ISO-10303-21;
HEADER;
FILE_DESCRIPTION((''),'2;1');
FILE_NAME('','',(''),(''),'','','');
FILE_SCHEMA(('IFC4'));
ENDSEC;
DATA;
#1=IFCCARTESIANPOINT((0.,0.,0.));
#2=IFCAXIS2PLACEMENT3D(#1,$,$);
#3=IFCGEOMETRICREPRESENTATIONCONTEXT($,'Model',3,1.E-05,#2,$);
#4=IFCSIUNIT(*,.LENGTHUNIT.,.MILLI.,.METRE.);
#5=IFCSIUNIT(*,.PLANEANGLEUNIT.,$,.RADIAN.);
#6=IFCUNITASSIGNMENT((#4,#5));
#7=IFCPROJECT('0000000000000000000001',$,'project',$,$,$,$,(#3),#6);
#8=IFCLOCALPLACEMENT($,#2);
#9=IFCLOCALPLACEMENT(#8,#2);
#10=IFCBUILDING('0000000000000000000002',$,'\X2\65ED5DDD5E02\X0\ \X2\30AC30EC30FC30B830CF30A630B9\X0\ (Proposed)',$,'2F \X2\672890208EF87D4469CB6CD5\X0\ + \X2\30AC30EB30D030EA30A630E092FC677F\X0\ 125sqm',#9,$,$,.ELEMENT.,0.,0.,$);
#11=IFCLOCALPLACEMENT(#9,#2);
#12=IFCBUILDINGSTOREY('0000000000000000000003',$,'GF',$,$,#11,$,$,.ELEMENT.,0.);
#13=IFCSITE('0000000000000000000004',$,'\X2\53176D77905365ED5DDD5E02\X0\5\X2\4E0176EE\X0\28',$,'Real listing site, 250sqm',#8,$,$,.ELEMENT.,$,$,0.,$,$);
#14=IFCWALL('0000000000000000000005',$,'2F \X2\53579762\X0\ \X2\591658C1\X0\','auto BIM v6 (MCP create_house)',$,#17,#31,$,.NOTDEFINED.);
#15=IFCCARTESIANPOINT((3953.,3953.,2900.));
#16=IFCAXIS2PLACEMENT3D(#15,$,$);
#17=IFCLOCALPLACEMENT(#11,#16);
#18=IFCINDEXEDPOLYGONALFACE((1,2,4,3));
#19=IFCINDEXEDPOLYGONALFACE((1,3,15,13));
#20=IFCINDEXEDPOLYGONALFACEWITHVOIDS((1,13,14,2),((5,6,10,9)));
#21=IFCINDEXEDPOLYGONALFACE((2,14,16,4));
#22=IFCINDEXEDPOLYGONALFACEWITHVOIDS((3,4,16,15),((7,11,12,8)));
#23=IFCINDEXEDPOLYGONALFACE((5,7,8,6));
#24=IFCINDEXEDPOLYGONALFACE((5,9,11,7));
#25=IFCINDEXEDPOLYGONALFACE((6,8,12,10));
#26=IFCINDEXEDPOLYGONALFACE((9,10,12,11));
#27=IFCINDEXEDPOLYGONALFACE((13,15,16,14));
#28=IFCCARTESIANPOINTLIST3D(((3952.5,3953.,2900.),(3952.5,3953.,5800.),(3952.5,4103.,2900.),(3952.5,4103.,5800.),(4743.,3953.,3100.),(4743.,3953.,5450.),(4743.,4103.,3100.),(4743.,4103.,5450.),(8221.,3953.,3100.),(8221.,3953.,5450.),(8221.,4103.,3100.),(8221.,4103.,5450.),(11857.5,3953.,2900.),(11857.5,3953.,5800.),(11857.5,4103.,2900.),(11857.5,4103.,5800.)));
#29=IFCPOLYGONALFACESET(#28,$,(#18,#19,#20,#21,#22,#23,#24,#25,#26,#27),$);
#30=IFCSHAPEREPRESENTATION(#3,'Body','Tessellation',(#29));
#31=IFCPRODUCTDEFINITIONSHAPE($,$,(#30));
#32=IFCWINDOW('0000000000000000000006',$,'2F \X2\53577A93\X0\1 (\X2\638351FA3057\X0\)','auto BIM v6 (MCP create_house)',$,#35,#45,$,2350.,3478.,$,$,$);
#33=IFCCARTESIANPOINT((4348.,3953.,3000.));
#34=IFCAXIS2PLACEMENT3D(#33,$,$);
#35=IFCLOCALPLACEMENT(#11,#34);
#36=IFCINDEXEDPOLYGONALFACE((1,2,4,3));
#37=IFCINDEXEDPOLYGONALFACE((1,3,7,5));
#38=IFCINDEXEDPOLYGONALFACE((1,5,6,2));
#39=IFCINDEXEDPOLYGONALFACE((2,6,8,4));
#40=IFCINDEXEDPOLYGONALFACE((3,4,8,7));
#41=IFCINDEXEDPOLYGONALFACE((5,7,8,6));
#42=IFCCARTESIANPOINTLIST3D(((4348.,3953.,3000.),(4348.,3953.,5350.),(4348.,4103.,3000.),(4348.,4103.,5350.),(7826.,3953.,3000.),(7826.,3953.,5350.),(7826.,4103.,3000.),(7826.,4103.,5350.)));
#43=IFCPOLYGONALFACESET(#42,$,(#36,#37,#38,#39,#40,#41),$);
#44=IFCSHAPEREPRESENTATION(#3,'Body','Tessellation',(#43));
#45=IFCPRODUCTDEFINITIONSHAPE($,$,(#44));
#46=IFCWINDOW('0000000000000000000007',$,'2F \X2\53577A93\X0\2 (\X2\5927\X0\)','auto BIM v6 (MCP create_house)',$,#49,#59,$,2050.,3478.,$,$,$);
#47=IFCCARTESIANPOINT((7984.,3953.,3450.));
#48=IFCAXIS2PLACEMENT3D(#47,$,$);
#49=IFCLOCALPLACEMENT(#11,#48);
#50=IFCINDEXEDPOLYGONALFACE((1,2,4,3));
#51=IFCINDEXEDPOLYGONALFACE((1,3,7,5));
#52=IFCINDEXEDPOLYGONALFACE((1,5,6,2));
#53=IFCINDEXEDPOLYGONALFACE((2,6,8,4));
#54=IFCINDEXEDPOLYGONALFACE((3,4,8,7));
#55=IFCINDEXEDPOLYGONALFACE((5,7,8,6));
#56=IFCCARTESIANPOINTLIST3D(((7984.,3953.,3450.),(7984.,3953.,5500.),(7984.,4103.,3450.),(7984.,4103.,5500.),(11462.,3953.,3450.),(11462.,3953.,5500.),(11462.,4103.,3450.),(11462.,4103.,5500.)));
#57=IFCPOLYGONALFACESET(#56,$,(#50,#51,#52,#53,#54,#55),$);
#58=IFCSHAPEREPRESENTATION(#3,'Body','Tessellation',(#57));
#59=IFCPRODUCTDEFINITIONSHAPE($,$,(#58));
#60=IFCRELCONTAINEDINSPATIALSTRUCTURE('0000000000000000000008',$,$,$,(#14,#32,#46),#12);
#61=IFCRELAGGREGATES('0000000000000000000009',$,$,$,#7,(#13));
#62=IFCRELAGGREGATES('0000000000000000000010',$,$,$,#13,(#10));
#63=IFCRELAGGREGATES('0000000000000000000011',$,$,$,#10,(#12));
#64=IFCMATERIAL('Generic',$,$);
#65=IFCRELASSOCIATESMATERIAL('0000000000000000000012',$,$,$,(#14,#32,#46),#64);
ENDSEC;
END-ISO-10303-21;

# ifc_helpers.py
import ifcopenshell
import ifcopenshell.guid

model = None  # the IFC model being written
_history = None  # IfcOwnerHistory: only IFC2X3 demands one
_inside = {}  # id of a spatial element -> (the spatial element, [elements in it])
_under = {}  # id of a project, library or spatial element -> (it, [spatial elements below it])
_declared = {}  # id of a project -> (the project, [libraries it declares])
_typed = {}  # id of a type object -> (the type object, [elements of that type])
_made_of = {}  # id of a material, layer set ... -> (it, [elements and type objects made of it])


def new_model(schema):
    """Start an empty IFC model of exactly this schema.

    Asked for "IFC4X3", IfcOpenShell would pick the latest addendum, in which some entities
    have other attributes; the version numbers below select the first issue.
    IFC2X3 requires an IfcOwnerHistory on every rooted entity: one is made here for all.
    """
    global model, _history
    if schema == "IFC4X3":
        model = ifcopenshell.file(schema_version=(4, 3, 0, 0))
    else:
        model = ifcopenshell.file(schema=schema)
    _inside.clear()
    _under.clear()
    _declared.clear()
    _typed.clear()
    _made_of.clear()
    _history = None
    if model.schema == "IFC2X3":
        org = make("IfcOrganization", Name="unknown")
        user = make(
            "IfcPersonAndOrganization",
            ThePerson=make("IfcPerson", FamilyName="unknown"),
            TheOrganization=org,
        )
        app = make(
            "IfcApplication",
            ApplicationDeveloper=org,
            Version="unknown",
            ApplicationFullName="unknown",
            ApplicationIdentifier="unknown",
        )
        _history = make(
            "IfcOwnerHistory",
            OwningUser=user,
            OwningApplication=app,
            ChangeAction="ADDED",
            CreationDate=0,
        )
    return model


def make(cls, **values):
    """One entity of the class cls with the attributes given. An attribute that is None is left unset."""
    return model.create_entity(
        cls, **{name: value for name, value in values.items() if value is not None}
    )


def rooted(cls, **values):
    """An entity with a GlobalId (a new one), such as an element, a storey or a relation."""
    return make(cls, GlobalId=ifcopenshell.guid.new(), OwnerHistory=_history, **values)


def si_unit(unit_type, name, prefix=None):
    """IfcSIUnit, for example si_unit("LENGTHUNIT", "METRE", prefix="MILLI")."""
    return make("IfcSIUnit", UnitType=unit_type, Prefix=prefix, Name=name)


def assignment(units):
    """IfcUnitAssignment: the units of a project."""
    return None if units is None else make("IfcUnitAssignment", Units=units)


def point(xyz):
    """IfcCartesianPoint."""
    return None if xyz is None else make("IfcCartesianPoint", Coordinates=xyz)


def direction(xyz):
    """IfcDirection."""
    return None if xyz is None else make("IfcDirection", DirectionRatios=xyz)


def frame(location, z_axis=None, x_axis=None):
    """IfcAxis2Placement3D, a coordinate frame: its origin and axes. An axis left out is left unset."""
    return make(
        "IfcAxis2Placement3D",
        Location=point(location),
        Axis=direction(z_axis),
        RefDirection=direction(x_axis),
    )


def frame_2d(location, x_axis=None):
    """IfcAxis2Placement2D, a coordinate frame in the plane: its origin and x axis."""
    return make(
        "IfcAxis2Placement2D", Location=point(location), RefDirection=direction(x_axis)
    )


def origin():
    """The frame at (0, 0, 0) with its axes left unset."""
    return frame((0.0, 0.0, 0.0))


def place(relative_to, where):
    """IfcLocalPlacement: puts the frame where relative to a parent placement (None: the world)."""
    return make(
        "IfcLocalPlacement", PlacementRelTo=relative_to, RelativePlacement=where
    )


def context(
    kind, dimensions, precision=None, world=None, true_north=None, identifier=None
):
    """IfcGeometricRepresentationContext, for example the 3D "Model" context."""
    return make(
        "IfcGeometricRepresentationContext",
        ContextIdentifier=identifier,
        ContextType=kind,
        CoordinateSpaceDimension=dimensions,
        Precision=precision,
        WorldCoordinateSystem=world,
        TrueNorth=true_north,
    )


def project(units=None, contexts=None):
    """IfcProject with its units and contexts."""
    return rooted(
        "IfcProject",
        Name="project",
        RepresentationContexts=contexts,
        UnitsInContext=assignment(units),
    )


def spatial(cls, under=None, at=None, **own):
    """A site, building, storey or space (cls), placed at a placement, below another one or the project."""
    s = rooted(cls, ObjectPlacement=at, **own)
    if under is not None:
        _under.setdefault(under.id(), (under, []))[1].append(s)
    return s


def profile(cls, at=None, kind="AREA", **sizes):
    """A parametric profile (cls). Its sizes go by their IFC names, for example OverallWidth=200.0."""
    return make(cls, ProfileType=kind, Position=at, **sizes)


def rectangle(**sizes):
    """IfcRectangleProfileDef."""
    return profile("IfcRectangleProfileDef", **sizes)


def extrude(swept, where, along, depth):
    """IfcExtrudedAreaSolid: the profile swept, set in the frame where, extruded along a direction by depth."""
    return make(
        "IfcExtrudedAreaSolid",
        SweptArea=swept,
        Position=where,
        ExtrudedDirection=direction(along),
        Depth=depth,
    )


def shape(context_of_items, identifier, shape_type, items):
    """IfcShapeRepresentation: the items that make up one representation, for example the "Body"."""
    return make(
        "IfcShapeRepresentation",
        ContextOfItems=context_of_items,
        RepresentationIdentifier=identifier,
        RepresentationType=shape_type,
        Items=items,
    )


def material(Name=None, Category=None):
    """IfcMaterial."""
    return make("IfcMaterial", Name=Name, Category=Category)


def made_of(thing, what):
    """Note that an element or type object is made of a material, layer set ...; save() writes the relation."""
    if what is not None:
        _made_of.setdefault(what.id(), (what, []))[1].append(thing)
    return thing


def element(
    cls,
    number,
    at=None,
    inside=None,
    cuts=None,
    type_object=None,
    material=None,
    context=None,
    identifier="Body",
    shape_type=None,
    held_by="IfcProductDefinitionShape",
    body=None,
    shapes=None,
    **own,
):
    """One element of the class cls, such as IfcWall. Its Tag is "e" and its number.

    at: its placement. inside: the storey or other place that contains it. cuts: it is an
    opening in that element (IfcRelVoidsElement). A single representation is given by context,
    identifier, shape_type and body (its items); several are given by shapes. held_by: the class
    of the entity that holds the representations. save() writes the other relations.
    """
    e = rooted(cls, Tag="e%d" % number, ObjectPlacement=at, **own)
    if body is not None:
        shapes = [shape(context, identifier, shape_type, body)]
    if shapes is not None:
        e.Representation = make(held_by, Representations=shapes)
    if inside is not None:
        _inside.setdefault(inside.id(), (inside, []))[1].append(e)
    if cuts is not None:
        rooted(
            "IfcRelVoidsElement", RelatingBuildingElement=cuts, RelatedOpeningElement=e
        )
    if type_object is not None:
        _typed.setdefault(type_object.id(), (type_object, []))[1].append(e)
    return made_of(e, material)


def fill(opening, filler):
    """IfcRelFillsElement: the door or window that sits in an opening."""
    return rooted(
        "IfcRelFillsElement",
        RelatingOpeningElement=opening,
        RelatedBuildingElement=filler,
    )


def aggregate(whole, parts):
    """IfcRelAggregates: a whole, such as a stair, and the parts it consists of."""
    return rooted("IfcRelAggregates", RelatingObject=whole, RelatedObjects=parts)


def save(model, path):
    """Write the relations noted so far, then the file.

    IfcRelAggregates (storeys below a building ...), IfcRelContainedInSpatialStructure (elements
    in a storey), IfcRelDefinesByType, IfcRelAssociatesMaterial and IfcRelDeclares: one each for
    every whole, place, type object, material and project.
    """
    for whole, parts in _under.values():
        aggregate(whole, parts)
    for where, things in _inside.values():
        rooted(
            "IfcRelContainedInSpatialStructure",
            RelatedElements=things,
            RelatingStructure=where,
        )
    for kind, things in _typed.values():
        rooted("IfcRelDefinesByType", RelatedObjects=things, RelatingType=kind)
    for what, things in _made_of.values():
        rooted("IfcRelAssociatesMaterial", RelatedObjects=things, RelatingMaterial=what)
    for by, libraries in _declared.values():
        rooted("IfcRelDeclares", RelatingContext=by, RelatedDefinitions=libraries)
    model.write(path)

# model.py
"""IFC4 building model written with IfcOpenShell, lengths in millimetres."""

from ifc_helpers import new_model, si_unit, frame, frame_2d, origin, place, context, project, spatial, rectangle, extrude, material, element, fill, save


model = new_model("IFC4")

# Units and contexts
model_context = context("Model", 3, precision=1e-05, world=origin())
ifc_project = project(units=[si_unit("LENGTHUNIT", "METRE", prefix="MILLI"), si_unit("PLANEANGLEUNIT", "RADIAN")], contexts=[model_context])

# Site, building, storey
site_placement = place(None, origin())
site = spatial("IfcSite", under=ifc_project, at=site_placement, Name="北海道旭川市5丁目28", ObjectType="Real listing site, 250sqm", CompositionType="ELEMENT", RefElevation=0.0)
building_placement = place(site_placement, origin())
building = spatial("IfcBuilding", under=site, at=building_placement, Name="旭川市 ガレージハウス (Proposed)", ObjectType="2F 木造軸組構法 + ガルバリウム鋼板 125sqm", CompositionType="ELEMENT", ElevationOfRefHeight=0.0, ElevationOfTerrain=0.0)
storey_placement = place(building_placement, origin())
storey = spatial("IfcBuildingStorey", under=building, at=storey_placement, Name="GF", CompositionType="ELEMENT", Elevation=0.0)

# Shared definitions
ifc_material = material(Name="Generic")

# Wall, openings, windows
wall_1_placement = place(storey_placement, frame((3953.0, 3953.0, 2900.0)))
wall_1 = element("IfcWall", 1, at=wall_1_placement, inside=storey, material=ifc_material, Name="2F 南面 外壁", Description="auto BIM v6 (MCP create_house)", PredefinedType="NOTDEFINED", context=model_context, shape_type="SweptSolid", body=[
    extrude(rectangle(XDim=7905.0, YDim=150.0, at=frame_2d((3952.0, 75.0))), frame((3953.0, 3953.0, 2900.0)), (0.0, 0.0, 1.0), 2900.0),
])
opening_1_placement = place(storey_placement, frame((4348.0, 3953.0, 3000.0)))
opening_1 = element("IfcOpeningElement", 2, at=opening_1_placement, cuts=wall_1, PredefinedType="NOTDEFINED", context=model_context, shape_type="SweptSolid", body=[
    extrude(rectangle(XDim=3478.0, YDim=150.0, at=frame_2d((1739.0, 75.0))), frame((4348.0, 3953.0, 3000.0)), (0.0, 0.0, 1.0), 2350.0),
])
opening_2_placement = place(storey_placement, frame((7984.0, 3953.0, 3450.0)))
opening_2 = element("IfcOpeningElement", 3, at=opening_2_placement, cuts=wall_1, PredefinedType="NOTDEFINED", context=model_context, shape_type="SweptSolid", body=[
    extrude(rectangle(XDim=3478.0, YDim=150.0, at=frame_2d((1739.0, 75.0))), frame((7984.0, 3953.0, 3450.0)), (0.0, 0.0, 1.0), 2050.0),
])
window_1_placement = place(storey_placement, frame((4348.0, 3953.0, 3000.0)))
window_1 = element("IfcWindow", 4, at=window_1_placement, inside=storey, material=ifc_material, Name="2F 南窓1 (掃出し)", Description="auto BIM v6 (MCP create_house)", OverallHeight=2350.0, OverallWidth=3478.0, context=model_context, shape_type="SweptSolid", body=[
    extrude(rectangle(XDim=3478.0, YDim=150.0, at=frame_2d((1739.0, 75.0))), frame((4348.0, 3953.0, 3000.0)), (0.0, 0.0, 1.0), 2350.0),
])
fill(opening_1, window_1)
window_2_placement = place(storey_placement, frame((7984.0, 3953.0, 3450.0)))
window_2 = element("IfcWindow", 5, at=window_2_placement, inside=storey, material=ifc_material, Name="2F 南窓2 (大)", Description="auto BIM v6 (MCP create_house)", OverallHeight=2050.0, OverallWidth=3478.0, context=model_context, shape_type="SweptSolid", body=[
    extrude(rectangle(XDim=3478.0, YDim=150.0, at=frame_2d((1739.0, 75.0))), frame((7984.0, 3953.0, 3450.0)), (0.0, 0.0, 1.0), 2050.0),
])
fill(opening_2, window_2)

save(model, "model.ifc")
